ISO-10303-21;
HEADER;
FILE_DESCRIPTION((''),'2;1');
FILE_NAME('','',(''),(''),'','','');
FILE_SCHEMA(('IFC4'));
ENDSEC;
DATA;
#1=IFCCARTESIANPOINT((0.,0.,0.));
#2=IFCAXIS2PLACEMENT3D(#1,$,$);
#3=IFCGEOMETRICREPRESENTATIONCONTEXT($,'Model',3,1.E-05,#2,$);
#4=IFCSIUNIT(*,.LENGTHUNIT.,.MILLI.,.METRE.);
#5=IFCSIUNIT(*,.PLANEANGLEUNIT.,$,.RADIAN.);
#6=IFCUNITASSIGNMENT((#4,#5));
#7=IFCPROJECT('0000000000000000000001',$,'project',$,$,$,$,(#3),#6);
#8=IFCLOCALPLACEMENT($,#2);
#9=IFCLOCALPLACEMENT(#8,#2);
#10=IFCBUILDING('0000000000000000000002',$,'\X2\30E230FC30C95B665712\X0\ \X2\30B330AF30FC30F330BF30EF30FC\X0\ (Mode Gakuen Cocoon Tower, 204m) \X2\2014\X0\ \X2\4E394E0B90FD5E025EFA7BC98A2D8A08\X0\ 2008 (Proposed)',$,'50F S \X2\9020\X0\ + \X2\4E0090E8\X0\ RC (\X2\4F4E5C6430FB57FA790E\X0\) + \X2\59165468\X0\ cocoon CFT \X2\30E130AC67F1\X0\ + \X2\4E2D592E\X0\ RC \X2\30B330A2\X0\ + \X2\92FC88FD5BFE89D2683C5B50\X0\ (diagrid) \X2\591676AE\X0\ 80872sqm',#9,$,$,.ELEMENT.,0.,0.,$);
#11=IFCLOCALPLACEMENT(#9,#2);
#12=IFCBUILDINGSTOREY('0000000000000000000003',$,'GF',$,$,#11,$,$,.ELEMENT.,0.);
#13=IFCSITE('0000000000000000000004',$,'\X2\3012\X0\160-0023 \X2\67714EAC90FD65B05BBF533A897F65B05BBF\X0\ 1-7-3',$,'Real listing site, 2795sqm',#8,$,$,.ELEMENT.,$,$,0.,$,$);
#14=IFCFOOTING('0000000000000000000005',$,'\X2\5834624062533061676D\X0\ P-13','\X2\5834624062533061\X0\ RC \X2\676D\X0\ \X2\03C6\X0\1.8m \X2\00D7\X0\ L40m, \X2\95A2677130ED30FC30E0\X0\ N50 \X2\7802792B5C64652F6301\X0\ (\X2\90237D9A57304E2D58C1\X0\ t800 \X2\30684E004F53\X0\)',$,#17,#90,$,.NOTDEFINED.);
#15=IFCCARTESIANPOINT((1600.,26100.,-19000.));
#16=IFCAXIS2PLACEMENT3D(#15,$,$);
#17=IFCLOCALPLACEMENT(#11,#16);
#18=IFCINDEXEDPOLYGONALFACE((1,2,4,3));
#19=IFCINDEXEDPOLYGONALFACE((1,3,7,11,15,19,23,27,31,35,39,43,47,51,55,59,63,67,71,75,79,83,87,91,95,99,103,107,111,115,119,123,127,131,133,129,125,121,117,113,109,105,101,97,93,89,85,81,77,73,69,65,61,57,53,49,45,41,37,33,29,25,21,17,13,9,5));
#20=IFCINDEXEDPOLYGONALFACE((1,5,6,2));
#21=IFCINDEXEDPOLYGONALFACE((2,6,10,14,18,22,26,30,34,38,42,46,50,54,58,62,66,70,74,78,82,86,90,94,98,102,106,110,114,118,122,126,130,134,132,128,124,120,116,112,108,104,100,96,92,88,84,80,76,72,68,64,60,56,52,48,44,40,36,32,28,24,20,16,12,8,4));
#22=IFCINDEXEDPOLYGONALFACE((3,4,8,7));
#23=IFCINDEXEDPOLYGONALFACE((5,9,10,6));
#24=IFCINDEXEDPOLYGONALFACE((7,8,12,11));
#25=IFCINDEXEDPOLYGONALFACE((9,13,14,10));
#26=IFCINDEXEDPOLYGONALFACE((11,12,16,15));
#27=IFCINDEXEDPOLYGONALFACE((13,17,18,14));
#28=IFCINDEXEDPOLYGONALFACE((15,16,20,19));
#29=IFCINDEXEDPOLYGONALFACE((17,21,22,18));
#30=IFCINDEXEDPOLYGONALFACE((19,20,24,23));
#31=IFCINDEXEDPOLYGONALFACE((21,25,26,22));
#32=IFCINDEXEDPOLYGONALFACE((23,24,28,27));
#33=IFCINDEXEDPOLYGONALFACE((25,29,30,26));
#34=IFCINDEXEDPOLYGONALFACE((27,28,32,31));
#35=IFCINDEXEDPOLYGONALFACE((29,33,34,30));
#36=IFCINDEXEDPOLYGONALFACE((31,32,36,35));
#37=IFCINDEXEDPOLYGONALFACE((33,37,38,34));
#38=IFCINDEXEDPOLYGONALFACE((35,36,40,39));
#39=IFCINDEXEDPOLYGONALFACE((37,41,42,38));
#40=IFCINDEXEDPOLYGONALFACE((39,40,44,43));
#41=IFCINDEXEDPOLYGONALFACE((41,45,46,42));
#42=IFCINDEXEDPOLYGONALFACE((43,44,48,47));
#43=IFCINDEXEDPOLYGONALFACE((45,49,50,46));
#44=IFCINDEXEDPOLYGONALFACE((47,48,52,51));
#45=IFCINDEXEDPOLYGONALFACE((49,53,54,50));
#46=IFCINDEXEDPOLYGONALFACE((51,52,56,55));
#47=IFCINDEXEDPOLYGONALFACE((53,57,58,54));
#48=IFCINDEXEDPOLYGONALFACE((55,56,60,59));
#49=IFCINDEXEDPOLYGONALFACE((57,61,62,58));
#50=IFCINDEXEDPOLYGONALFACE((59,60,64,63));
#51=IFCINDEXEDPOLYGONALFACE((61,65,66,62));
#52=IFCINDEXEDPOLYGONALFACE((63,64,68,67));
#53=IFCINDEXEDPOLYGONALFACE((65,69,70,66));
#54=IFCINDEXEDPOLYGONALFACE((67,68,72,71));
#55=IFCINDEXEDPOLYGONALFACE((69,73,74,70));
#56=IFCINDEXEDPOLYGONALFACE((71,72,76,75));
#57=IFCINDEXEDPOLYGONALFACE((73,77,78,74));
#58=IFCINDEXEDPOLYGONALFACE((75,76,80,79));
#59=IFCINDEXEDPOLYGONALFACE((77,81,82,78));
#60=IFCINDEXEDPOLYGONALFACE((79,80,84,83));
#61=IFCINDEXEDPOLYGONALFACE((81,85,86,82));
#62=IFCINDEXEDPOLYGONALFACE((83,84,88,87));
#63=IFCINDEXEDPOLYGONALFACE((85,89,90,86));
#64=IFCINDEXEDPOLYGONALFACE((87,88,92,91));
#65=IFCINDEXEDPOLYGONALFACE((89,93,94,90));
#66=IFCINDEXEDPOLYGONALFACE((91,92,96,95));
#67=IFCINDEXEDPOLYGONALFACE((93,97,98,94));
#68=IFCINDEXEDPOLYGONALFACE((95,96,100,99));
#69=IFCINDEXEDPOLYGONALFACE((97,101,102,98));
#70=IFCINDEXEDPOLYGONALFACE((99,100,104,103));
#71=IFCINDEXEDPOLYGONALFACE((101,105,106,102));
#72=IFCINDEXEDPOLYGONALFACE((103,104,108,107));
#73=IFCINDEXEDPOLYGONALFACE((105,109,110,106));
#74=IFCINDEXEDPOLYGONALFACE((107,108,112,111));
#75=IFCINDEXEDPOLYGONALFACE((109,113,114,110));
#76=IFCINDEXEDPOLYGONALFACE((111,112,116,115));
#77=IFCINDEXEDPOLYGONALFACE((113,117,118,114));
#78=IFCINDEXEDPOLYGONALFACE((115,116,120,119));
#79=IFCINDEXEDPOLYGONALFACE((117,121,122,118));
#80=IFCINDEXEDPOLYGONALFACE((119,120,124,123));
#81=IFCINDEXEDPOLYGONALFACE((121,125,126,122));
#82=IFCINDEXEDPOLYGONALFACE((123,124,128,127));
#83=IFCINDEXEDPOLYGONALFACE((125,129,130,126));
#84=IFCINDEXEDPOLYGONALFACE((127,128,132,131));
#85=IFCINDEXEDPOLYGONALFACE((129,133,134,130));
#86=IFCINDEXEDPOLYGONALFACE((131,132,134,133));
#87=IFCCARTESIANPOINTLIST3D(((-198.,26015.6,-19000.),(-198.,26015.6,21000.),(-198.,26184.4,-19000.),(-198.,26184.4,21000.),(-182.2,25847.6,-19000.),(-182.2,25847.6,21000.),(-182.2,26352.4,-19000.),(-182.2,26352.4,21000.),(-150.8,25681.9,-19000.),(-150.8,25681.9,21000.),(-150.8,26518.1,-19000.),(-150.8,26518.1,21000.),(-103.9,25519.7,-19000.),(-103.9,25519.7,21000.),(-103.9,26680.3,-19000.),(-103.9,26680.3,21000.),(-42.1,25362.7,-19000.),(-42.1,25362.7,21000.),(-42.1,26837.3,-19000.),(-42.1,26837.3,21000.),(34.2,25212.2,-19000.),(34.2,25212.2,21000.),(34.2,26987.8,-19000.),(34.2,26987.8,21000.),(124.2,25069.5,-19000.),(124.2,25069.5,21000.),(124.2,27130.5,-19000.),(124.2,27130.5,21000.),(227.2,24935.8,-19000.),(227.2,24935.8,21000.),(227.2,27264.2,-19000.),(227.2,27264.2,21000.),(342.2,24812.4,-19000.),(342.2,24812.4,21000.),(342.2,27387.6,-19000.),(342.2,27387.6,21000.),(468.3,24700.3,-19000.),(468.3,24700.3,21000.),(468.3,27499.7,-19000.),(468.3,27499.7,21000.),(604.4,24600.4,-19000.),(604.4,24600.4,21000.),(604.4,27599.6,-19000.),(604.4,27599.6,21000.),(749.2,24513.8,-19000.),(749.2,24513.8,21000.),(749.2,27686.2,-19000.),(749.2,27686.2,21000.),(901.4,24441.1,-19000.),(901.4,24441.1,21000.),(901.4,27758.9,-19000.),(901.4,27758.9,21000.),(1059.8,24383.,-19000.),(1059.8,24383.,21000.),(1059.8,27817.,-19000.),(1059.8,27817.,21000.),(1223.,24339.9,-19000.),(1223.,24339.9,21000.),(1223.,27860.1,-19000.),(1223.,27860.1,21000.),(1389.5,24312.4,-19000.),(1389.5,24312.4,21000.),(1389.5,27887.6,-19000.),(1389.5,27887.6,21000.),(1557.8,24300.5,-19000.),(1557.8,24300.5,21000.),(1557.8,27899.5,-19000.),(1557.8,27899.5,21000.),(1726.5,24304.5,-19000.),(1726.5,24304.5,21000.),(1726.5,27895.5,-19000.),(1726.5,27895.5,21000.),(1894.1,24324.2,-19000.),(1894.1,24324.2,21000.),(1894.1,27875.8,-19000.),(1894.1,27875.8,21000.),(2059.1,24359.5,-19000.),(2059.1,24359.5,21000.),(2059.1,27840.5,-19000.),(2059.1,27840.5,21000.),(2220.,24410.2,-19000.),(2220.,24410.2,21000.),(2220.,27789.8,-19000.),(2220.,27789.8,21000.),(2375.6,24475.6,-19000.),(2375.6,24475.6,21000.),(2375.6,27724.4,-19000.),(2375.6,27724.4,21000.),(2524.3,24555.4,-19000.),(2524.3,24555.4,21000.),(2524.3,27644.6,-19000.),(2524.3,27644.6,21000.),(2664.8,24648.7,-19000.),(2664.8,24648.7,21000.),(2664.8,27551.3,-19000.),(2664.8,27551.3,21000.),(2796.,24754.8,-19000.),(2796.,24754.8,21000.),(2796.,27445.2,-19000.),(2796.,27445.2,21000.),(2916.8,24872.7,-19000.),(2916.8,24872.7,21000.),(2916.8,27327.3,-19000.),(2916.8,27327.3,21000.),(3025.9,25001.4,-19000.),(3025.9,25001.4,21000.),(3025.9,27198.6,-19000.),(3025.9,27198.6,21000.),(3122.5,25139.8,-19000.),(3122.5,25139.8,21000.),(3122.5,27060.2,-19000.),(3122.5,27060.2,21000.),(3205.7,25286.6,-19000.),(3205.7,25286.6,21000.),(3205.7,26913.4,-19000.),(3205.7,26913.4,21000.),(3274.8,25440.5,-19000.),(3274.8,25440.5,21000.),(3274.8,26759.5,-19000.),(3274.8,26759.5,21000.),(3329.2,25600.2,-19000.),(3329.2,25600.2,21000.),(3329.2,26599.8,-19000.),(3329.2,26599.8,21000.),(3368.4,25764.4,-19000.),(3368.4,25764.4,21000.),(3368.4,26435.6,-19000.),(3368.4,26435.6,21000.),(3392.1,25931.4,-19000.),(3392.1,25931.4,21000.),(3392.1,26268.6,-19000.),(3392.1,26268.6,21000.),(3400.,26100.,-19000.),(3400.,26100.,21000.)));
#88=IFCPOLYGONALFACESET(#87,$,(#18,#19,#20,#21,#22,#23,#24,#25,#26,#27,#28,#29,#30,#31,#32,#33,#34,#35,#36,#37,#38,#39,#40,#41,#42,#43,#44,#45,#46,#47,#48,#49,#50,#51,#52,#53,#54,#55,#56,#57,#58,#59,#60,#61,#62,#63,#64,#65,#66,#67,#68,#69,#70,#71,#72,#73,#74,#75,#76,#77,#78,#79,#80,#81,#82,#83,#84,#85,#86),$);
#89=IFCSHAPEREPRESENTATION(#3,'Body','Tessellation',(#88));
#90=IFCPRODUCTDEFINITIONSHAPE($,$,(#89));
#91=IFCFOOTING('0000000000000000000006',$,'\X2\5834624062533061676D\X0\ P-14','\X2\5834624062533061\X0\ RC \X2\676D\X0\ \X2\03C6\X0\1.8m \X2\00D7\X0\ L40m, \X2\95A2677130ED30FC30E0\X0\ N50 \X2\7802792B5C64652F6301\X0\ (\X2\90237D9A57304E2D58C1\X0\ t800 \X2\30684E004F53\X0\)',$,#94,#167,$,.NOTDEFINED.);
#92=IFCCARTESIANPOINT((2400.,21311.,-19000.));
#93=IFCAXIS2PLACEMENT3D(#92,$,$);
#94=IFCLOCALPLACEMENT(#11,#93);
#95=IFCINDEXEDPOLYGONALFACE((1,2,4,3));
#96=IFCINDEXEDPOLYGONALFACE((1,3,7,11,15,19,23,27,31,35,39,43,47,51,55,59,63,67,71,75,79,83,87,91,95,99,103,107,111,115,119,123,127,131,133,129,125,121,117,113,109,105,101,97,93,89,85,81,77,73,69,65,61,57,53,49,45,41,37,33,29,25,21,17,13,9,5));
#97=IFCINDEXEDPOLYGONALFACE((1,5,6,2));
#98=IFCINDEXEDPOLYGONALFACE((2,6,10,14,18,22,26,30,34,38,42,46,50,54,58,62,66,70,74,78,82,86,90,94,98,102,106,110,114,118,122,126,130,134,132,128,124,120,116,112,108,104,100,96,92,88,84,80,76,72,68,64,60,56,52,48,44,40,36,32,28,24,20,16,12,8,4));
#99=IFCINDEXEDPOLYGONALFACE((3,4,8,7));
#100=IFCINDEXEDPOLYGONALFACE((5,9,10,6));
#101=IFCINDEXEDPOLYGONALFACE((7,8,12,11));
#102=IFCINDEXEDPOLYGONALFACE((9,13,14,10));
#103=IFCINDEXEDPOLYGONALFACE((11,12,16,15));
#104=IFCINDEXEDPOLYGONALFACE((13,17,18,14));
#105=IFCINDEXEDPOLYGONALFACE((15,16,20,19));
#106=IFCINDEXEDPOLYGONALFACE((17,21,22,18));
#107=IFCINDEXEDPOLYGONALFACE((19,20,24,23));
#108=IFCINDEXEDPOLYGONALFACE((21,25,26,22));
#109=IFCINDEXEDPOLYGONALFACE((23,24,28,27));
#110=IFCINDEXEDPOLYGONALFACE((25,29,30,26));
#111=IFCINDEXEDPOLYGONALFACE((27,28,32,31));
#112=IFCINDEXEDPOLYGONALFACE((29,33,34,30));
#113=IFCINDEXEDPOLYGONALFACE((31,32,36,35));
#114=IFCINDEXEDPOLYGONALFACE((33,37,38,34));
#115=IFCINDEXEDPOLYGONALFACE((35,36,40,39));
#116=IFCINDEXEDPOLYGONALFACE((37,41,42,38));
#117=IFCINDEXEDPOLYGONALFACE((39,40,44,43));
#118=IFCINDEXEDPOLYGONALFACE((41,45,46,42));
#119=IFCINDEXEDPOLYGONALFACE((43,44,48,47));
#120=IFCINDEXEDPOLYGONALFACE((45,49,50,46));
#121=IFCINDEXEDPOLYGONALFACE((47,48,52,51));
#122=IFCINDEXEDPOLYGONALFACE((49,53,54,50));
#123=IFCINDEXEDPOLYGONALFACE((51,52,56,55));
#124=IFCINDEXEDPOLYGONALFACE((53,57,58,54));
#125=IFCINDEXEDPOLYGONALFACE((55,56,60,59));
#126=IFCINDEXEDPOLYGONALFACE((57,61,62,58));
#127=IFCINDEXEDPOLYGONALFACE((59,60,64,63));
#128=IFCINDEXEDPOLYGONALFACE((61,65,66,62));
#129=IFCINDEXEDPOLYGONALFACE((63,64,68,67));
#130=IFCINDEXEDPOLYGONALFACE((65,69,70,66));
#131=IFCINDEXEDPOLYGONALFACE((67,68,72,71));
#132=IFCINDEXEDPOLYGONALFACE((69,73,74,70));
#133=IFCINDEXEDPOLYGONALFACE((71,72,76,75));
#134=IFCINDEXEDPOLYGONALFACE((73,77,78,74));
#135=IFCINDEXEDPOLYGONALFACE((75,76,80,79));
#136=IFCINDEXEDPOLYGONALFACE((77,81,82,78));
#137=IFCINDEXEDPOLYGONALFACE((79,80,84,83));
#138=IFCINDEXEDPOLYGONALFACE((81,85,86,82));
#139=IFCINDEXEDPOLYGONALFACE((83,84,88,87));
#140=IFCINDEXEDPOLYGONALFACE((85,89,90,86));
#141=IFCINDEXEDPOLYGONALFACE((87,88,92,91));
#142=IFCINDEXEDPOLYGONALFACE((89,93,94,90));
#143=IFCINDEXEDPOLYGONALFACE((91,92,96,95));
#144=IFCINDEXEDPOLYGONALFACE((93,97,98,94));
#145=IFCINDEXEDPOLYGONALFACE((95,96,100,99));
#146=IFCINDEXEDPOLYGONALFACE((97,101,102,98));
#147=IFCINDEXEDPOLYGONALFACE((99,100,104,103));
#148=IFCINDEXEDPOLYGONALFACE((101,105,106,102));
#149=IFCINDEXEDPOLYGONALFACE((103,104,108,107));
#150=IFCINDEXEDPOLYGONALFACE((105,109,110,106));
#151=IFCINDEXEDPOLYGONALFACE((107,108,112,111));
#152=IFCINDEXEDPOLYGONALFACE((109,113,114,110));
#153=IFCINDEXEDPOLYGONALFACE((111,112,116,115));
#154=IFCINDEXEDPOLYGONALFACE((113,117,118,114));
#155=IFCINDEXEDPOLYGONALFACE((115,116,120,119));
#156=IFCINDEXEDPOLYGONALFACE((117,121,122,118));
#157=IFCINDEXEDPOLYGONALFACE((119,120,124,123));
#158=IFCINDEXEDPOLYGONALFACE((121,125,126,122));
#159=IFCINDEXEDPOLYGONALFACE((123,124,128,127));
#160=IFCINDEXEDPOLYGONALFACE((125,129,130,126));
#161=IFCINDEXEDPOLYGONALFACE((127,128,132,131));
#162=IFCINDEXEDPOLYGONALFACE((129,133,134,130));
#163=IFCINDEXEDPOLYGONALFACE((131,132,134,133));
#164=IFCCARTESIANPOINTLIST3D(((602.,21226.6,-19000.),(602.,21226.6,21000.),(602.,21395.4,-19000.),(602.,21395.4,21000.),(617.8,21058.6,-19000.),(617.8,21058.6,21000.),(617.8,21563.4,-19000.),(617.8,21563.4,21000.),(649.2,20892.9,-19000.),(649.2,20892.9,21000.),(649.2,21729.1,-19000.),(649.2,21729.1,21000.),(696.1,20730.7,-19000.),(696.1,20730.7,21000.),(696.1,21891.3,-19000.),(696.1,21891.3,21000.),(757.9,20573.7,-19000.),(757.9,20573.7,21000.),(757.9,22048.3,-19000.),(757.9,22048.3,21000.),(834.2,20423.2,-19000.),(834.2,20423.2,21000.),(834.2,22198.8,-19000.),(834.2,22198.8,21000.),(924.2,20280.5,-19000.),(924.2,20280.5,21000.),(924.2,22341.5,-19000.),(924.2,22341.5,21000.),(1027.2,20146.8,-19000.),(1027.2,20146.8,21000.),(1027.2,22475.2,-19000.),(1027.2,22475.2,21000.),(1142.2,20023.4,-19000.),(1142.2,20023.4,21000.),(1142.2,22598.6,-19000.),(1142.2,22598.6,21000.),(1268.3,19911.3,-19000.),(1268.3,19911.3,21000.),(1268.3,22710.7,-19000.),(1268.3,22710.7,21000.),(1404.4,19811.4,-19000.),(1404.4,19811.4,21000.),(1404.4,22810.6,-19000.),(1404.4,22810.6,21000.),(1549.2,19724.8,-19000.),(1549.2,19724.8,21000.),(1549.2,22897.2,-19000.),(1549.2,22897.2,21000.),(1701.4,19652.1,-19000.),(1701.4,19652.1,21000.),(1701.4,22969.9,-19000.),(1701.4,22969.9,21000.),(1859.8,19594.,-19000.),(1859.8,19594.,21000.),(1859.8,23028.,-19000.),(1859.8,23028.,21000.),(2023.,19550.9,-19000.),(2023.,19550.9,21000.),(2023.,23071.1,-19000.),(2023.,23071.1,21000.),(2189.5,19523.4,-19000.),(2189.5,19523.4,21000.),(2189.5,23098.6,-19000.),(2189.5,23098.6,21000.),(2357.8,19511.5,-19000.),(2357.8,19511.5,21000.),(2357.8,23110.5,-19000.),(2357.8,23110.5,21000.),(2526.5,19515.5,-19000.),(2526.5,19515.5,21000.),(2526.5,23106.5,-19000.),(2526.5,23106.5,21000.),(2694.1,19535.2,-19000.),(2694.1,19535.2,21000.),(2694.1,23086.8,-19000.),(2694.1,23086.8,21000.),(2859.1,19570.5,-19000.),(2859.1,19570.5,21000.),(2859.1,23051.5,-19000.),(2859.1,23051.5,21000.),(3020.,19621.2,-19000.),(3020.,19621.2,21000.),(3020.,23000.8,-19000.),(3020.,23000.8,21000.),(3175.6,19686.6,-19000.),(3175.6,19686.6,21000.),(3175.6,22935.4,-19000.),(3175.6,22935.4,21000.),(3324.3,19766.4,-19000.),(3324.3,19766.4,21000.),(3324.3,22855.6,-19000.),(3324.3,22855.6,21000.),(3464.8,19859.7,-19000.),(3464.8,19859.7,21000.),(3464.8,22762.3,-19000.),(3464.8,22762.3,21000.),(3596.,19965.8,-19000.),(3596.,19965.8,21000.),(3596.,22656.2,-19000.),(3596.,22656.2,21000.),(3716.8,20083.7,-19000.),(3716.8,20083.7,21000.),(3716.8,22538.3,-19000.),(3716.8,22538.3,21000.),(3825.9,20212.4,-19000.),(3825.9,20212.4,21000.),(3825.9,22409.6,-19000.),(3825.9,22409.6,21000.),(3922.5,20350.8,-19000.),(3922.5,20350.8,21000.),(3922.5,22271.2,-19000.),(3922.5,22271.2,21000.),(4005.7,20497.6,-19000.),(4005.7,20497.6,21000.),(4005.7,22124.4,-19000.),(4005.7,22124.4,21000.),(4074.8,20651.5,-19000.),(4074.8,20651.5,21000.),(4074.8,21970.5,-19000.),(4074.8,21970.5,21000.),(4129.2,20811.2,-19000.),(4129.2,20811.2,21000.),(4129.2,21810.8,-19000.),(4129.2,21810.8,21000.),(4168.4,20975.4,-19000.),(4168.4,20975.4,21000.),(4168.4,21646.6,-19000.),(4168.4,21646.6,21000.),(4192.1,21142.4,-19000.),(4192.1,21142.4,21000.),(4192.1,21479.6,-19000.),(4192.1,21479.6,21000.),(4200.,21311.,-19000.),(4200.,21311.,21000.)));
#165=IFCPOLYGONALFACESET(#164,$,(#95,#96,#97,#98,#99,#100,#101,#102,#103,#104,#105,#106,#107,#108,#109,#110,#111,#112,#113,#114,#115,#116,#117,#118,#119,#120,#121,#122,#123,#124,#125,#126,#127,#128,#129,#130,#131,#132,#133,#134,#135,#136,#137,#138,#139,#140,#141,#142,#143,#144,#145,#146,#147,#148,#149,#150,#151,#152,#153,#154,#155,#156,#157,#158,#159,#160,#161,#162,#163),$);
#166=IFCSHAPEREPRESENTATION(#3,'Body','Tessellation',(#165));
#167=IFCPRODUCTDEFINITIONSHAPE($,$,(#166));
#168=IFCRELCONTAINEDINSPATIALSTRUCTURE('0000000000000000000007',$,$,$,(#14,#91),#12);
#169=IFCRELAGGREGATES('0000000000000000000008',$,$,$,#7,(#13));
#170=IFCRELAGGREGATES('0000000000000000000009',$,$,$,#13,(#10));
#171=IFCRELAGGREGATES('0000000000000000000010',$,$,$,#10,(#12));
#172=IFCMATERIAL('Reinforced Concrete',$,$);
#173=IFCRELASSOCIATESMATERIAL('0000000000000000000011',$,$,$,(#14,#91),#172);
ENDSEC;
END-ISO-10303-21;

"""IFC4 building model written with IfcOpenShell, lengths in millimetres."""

from ifc_helpers import new_model, si_unit, frame, origin, origin_2d, place, context, project, spatial, circle, extrude, material, element, save


model = new_model("IFC4")

# Units and contexts
model_context = context("Model", 3, precision=1e-05, world=origin())
ifc_project = project(units=[si_unit("LENGTHUNIT", "METRE", prefix="MILLI"), si_unit("PLANEANGLEUNIT", "RADIAN")], contexts=[model_context])

# Site, building, storey
site_placement = place(None, origin())
site = spatial("IfcSite", under=ifc_project, at=site_placement, Name="〒160-0023 東京都新宿区西新宿 1-7-3", ObjectType="Real listing site, 2795sqm", CompositionType="ELEMENT", RefElevation=0.0)
building_placement = place(site_placement, origin())
building = spatial("IfcBuilding", under=site, at=building_placement, Name="モード学園 コクーンタワー (Mode Gakuen Cocoon Tower, 204m) — 丹下都市建築設計 2008 (Proposed)", ObjectType="50F S 造 + 一部 RC (低層・基礎) + 外周 cocoon CFT メガ柱 + 中央 RC コア + 鋼製対角格子 (diagrid) 外皮 80872sqm", CompositionType="ELEMENT", ElevationOfRefHeight=0.0, ElevationOfTerrain=0.0)
storey_placement = place(building_placement, origin())
storey = spatial("IfcBuildingStorey", under=building, at=storey_placement, Name="GF", CompositionType="ELEMENT", Elevation=0.0)

# Footings
ifc_material_1 = material(Name="Reinforced Concrete")
footing_1_placement = place(storey_placement, frame((1600.0, 26100.0, -19000.0)))
element("IfcFooting", 1, at=footing_1_placement, inside=storey, material=ifc_material_1, Name="場所打ち杭 P-13", Description="場所打ち RC 杭 φ1.8m × L40m, 関東ローム N50 砂礫層支持 (連続地中壁 t800 と一体)", PredefinedType="NOTDEFINED", context=model_context, shape_type="SweptSolid", body=[
    extrude(circle(Radius=1800.0, at=origin_2d()), frame((1600.0, 26100.0, -19000.0)), (0.0, 0.0, 1.0), 40000.0),
])
footing_2_placement = place(storey_placement, frame((2400.0, 21311.0, -19000.0)))
element("IfcFooting", 2, at=footing_2_placement, inside=storey, material=ifc_material_1, Name="場所打ち杭 P-14", Description="場所打ち RC 杭 φ1.8m × L40m, 関東ローム N50 砂礫層支持 (連続地中壁 t800 と一体)", PredefinedType="NOTDEFINED", context=model_context, shape_type="SweptSolid", body=[
    extrude(circle(Radius=1800.0, at=origin_2d()), frame((2400.0, 21311.0, -19000.0)), (0.0, 0.0, 1.0), 40000.0),
])

save(model, "model.ifc")
